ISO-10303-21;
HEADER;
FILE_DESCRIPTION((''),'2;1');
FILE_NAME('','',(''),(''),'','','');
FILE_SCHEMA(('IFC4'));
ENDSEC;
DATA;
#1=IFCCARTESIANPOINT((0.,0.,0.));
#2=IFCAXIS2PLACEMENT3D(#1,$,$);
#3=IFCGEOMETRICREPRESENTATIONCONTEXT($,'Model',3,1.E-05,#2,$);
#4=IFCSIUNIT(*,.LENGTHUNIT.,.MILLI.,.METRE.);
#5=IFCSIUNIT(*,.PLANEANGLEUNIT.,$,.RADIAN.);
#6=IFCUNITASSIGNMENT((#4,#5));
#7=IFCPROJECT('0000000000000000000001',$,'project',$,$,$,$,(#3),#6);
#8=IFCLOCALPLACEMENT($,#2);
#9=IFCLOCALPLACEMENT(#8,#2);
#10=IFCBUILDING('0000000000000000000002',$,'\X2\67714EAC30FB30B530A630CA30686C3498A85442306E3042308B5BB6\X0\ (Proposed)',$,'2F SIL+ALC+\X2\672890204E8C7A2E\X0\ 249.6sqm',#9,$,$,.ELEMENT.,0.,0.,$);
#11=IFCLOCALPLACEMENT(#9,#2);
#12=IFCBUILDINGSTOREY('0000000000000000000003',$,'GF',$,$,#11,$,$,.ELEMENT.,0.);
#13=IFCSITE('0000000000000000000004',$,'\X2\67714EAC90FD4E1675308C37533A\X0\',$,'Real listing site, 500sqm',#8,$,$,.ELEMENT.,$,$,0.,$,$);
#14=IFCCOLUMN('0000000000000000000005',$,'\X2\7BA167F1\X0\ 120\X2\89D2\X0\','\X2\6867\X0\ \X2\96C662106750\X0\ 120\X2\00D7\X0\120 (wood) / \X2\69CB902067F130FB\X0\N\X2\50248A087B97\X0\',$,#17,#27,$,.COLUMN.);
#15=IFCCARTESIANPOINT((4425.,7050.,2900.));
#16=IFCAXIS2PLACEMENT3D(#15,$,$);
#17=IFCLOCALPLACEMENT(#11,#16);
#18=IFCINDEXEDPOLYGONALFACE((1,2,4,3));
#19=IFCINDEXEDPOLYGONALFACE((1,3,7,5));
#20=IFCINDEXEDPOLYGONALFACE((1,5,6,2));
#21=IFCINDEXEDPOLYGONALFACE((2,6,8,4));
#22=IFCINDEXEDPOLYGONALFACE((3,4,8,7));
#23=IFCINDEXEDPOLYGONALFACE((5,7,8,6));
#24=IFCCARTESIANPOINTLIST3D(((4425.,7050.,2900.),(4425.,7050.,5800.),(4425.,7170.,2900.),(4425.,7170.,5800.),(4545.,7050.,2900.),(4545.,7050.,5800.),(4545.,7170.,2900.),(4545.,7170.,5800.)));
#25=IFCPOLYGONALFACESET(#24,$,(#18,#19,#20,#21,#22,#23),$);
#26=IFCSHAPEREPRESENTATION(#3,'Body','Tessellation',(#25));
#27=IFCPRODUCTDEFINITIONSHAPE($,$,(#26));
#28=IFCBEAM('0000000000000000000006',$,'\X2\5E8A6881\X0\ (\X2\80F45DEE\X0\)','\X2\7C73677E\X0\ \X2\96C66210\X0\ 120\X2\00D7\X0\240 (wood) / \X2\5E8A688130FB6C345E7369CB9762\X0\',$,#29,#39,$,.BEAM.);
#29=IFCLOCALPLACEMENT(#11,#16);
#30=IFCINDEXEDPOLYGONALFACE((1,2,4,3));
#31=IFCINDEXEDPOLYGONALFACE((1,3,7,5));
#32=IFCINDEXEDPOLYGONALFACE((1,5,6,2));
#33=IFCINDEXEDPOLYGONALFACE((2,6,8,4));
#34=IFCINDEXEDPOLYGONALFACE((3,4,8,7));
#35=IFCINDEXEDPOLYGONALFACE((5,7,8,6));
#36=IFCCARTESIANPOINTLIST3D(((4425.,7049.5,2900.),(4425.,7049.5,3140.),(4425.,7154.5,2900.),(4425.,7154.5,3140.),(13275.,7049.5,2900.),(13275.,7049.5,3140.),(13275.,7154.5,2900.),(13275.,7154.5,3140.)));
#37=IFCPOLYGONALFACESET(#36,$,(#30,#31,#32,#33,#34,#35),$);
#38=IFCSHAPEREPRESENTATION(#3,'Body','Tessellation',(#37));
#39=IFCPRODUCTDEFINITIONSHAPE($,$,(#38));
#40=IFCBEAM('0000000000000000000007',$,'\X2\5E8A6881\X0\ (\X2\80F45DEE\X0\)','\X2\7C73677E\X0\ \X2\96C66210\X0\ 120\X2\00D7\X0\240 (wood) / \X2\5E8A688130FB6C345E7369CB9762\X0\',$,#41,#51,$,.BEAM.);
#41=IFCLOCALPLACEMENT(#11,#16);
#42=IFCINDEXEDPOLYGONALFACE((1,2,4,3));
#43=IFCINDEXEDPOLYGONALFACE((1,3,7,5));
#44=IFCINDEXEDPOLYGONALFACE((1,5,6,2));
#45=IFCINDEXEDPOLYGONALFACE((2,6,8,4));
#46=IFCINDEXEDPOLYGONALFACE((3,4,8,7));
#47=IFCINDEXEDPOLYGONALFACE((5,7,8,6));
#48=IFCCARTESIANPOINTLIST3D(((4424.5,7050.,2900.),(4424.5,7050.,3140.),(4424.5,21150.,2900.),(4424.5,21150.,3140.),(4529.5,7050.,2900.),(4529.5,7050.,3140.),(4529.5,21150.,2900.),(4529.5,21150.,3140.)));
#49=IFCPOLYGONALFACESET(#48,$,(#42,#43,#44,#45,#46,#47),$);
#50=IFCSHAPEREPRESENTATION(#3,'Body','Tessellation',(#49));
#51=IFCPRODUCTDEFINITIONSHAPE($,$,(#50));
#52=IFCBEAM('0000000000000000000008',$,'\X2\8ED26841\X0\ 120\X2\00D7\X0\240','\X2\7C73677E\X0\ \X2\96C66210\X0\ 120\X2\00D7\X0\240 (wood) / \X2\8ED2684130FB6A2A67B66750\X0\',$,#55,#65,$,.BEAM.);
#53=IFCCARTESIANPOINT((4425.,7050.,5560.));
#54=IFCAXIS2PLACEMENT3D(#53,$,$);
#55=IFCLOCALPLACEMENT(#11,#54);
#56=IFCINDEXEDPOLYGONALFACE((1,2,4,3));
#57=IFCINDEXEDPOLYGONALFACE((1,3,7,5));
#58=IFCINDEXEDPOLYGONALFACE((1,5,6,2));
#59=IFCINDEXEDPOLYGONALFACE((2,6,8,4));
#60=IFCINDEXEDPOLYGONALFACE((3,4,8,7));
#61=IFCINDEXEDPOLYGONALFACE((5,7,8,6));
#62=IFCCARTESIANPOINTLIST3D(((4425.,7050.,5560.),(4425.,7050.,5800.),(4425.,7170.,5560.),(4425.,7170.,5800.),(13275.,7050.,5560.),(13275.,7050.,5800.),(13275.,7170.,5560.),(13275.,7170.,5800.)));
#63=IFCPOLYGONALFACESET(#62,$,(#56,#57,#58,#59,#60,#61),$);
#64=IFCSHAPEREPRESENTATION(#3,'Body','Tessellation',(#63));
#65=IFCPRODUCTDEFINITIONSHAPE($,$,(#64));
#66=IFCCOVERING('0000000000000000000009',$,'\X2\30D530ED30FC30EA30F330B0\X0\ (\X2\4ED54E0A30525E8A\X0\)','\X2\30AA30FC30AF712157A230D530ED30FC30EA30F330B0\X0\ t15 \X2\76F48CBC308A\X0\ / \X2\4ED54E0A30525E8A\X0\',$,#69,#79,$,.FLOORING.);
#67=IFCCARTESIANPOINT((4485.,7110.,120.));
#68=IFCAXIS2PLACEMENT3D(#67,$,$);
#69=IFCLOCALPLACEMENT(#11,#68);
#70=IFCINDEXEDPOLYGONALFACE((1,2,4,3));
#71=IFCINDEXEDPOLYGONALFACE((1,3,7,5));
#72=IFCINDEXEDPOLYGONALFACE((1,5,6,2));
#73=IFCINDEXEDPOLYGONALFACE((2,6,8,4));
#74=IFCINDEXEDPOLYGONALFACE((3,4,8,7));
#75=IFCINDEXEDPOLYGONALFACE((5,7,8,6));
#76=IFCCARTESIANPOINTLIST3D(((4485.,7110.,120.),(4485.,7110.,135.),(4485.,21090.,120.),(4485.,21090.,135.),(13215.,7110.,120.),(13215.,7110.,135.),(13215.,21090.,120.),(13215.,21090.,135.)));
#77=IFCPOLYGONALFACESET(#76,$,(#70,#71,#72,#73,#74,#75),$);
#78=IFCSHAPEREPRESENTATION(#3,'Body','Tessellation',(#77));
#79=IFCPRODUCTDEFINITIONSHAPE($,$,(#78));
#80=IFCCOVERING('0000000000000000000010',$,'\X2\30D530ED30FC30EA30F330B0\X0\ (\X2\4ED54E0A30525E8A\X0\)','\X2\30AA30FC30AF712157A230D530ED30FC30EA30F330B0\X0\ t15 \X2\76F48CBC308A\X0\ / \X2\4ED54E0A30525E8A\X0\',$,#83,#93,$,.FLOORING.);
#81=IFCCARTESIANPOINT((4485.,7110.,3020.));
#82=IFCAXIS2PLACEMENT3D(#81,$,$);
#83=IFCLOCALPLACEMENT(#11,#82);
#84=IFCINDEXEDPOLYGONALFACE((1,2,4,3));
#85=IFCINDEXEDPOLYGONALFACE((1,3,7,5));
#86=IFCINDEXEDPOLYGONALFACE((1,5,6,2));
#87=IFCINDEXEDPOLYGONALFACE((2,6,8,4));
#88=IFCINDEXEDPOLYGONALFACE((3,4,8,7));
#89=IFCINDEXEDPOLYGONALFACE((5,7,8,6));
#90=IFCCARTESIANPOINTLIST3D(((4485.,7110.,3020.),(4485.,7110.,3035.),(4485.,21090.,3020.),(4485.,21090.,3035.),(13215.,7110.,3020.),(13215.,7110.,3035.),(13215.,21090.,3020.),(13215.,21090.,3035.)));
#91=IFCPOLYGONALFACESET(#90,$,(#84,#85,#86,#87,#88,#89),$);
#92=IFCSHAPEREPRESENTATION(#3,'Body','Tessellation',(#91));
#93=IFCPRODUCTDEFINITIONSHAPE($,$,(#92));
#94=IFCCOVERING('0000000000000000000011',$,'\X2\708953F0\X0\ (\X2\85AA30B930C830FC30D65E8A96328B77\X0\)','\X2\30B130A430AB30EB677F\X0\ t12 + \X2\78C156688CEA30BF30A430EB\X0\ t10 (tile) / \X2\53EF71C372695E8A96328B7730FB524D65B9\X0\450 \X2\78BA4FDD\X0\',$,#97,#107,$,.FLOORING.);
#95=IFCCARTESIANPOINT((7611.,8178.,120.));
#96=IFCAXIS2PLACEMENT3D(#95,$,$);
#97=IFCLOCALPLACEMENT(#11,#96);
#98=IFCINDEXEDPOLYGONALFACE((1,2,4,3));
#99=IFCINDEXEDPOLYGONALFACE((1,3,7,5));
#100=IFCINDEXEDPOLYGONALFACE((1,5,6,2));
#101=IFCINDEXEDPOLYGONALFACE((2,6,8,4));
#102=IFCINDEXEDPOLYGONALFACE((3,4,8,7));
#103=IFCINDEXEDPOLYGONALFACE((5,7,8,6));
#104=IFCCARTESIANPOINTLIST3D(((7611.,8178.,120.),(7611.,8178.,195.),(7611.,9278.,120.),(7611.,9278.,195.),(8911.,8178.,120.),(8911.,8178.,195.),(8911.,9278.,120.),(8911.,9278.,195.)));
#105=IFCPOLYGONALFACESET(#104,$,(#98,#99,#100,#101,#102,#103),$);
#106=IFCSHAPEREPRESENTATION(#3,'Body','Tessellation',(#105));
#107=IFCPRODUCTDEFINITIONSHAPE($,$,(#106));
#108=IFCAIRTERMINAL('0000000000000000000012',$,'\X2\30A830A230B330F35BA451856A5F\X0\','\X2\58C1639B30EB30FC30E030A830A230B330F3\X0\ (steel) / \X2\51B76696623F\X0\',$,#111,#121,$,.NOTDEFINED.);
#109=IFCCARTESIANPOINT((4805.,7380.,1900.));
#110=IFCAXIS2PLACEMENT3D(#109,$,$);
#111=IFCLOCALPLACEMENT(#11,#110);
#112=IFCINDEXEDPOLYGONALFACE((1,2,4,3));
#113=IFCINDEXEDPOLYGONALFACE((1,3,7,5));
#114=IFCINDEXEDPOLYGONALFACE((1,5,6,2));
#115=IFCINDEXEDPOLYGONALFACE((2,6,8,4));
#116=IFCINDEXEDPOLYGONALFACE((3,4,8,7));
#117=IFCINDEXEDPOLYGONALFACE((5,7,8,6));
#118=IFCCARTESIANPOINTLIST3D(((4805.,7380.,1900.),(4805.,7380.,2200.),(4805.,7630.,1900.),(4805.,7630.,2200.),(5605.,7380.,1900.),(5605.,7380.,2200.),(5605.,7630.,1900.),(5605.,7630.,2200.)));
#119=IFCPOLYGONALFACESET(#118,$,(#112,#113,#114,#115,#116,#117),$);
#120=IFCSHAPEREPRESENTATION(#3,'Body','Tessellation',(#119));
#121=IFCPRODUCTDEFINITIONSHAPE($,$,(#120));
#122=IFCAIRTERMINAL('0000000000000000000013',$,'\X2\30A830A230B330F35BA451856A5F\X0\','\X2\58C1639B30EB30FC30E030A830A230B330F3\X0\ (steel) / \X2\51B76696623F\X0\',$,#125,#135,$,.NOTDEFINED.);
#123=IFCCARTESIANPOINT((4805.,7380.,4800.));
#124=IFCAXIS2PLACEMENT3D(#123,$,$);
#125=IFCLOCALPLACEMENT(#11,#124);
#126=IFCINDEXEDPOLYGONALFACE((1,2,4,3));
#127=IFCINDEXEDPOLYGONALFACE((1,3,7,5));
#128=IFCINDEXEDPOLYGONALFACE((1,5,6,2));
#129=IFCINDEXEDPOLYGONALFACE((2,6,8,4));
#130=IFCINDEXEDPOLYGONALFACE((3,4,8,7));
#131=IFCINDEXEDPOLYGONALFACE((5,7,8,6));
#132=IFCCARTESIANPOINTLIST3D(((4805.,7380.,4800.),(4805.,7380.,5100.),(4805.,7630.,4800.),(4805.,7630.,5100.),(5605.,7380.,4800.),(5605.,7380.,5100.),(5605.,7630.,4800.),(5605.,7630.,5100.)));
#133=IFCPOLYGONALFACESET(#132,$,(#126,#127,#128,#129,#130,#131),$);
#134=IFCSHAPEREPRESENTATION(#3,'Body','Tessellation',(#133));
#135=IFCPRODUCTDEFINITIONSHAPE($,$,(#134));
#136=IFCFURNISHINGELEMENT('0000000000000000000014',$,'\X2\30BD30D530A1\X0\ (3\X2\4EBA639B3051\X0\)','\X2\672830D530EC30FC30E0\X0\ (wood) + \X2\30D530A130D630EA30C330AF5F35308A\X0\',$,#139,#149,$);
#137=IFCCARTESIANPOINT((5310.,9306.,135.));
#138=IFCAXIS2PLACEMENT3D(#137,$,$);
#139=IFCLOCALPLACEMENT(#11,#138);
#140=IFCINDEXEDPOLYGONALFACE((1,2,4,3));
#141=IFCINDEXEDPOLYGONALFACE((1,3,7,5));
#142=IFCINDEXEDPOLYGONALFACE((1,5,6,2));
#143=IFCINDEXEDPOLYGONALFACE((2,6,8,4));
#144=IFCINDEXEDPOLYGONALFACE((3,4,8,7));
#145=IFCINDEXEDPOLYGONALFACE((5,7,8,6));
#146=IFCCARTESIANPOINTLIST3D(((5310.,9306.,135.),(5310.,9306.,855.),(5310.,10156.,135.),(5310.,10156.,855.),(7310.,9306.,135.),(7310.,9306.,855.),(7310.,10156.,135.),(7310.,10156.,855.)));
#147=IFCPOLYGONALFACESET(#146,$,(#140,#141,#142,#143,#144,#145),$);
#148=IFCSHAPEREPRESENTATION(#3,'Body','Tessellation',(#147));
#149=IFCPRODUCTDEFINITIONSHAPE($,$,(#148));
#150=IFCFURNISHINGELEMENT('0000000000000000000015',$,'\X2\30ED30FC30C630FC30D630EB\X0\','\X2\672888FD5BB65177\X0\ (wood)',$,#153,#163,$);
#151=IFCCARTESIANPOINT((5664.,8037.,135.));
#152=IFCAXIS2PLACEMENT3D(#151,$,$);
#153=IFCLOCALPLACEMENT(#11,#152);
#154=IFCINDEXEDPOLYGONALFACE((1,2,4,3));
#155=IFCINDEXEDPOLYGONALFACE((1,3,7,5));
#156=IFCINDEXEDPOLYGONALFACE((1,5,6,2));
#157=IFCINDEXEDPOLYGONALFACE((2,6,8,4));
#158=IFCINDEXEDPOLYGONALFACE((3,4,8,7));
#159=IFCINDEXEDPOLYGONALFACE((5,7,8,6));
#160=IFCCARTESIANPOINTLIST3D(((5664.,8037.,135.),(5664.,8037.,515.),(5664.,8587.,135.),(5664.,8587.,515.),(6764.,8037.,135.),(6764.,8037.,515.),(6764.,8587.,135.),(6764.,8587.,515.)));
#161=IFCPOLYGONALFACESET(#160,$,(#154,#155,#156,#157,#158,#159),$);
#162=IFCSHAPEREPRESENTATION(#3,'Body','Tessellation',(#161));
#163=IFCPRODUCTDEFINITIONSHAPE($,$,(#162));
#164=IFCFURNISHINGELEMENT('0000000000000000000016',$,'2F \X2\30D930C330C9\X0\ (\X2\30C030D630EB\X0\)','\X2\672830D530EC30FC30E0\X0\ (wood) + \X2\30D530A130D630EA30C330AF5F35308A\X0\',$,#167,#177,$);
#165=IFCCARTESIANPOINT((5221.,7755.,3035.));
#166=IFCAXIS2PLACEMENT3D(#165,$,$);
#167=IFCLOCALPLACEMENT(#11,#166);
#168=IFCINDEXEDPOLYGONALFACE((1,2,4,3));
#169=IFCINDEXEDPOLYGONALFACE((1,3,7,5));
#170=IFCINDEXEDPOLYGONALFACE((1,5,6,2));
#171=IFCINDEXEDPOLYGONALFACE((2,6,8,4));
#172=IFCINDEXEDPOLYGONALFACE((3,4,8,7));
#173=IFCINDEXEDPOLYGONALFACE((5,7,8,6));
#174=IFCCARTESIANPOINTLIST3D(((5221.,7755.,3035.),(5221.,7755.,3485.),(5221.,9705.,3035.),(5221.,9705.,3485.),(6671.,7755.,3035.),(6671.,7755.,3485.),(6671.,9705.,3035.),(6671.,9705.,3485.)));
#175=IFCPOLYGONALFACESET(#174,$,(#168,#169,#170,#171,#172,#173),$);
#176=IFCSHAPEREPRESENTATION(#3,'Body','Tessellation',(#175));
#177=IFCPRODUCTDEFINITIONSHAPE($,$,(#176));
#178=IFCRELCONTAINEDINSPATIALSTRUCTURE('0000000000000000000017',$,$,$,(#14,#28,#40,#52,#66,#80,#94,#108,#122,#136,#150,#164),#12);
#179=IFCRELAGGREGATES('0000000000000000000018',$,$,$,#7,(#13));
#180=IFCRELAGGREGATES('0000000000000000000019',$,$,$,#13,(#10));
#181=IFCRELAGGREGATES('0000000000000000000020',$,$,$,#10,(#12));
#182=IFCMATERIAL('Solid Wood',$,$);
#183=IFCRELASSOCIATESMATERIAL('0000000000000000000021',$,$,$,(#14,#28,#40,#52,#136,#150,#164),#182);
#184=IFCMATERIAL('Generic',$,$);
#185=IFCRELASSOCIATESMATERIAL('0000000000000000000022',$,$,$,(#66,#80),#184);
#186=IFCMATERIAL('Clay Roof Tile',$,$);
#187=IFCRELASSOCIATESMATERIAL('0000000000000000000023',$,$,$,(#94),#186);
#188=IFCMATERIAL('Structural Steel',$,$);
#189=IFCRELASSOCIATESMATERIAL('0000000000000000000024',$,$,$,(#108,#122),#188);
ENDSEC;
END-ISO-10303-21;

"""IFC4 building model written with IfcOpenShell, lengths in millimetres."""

from ifc_helpers import new_model, si_unit, frame, frame_2d, origin, place, context, project, spatial, rectangle, extrude, material, element, save


model = new_model("IFC4")

# Units and contexts
model_context = context("Model", 3, precision=1e-05, world=origin())
ifc_project = project(units=[si_unit("LENGTHUNIT", "METRE", prefix="MILLI"), si_unit("PLANEANGLEUNIT", "RADIAN")], contexts=[model_context])

# Site, building, storey
site_placement = place(None, origin())
site = spatial("IfcSite", under=ifc_project, at=site_placement, Name="東京都世田谷区", ObjectType="Real listing site, 500sqm", CompositionType="ELEMENT", RefElevation=0.0)
building_placement = place(site_placement, origin())
building = spatial("IfcBuilding", under=site, at=building_placement, Name="東京・サウナと水風呂のある家 (Proposed)", ObjectType="2F SIL+ALC+木造二種 249.6sqm", CompositionType="ELEMENT", ElevationOfRefHeight=0.0, ElevationOfTerrain=0.0)
storey_placement = place(building_placement, origin())
storey = spatial("IfcBuildingStorey", under=building, at=storey_placement, Name="GF", CompositionType="ELEMENT", Elevation=0.0)

# Column
ifc_material_1 = material(Name="Solid Wood")
column_1_placement = place(storey_placement, frame((4425.0, 7050.0, 2900.0)))
element("IfcColumn", 1, at=column_1_placement, inside=storey, material=ifc_material_1, Name="管柱 120角", Description="桧 集成材 120×120 (wood) / 構造柱・N値計算", PredefinedType="COLUMN", context=model_context, shape_type="SweptSolid", body=[
    extrude(rectangle(XDim=120.0, YDim=120.0, at=frame_2d((60.0, 60.0))), frame((4425.0, 7050.0, 2900.0)), (0.0, 0.0, 1.0), 2900.0),
])

# Beams
beam_1_placement = place(storey_placement, frame((4425.0, 7050.0, 2900.0)))
element("IfcBeam", 2, at=beam_1_placement, inside=storey, material=ifc_material_1, Name="床梁 (胴差)", Description="米松 集成 120×240 (wood) / 床梁・水平構面", PredefinedType="BEAM", context=model_context, shape_type="SweptSolid", body=[
    extrude(rectangle(XDim=8850.0, YDim=105.0, at=frame_2d((4425.0, 52.0))), frame((4425.0, 7050.0, 2900.0)), (0.0, 0.0, 1.0), 240.0),
])
beam_2_placement = place(storey_placement, frame((4425.0, 7050.0, 2900.0)))
element("IfcBeam", 3, at=beam_2_placement, inside=storey, material=ifc_material_1, Name="床梁 (胴差)", Description="米松 集成 120×240 (wood) / 床梁・水平構面", PredefinedType="BEAM", context=model_context, shape_type="SweptSolid", body=[
    extrude(rectangle(XDim=105.0, YDim=14100.0, at=frame_2d((52.0, 7050.0))), frame((4425.0, 7050.0, 2900.0)), (0.0, 0.0, 1.0), 240.0),
])
beam_3_placement = place(storey_placement, frame((4425.0, 7050.0, 5560.0)))
element("IfcBeam", 4, at=beam_3_placement, inside=storey, material=ifc_material_1, Name="軒桁 120×240", Description="米松 集成 120×240 (wood) / 軒桁・横架材", PredefinedType="BEAM", context=model_context, shape_type="SweptSolid", body=[
    extrude(rectangle(XDim=8850.0, YDim=120.0, at=frame_2d((4425.0, 60.0))), frame((4425.0, 7050.0, 5560.0)), (0.0, 0.0, 1.0), 240.0),
])

# Coverings
ifc_material_2 = material(Name="Generic")
covering_1_placement = place(storey_placement, frame((4485.0, 7110.0, 120.0)))
element("IfcCovering", 5, at=covering_1_placement, inside=storey, material=ifc_material_2, Name="フローリング (仕上げ床)", Description="オーク無垢フローリング t15 直貼り / 仕上げ床", PredefinedType="FLOORING", context=model_context, shape_type="SweptSolid", body=[
    extrude(rectangle(XDim=8730.0, YDim=13980.0, at=frame_2d((4365.0, 6990.0))), frame((4485.0, 7110.0, 120.0)), (0.0, 0.0, 1.0), 15.0),
])
covering_2_placement = place(storey_placement, frame((4485.0, 7110.0, 3020.0)))
element("IfcCovering", 6, at=covering_2_placement, inside=storey, material=ifc_material_2, Name="フローリング (仕上げ床)", Description="オーク無垢フローリング t15 直貼り / 仕上げ床", PredefinedType="FLOORING", context=model_context, shape_type="SweptSolid", body=[
    extrude(rectangle(XDim=8730.0, YDim=13980.0, at=frame_2d((4365.0, 6990.0))), frame((4485.0, 7110.0, 3020.0)), (0.0, 0.0, 1.0), 15.0),
])
ifc_material_3 = material(Name="Clay Roof Tile")
covering_3_placement = place(storey_placement, frame((7611.0, 8178.0, 120.0)))
element("IfcCovering", 7, at=covering_3_placement, inside=storey, material=ifc_material_3, Name="炉台 (薪ストーブ床防護)", Description="ケイカル板 t12 + 磁器質タイル t10 (tile) / 可燃物床防護・前方450 確保", PredefinedType="FLOORING", context=model_context, shape_type="SweptSolid", body=[
    extrude(rectangle(XDim=1300.0, YDim=1100.0, at=frame_2d((650.0, 550.0))), frame((7611.0, 8178.0, 120.0)), (0.0, 0.0, 1.0), 75.0),
])

# Air terminals
ifc_material_4 = material(Name="Structural Steel")
air_terminal_1_placement = place(storey_placement, frame((4805.0, 7380.0, 1900.0)))
element("IfcAirTerminal", 8, at=air_terminal_1_placement, inside=storey, material=ifc_material_4, Name="エアコン室内機", Description="壁掛ルームエアコン (steel) / 冷暖房", PredefinedType="NOTDEFINED", context=model_context, shape_type="SweptSolid", body=[
    extrude(rectangle(XDim=800.0, YDim=250.0, at=frame_2d((400.0, 125.0))), frame((4805.0, 7380.0, 1900.0)), (0.0, 0.0, 1.0), 300.0),
])
air_terminal_2_placement = place(storey_placement, frame((4805.0, 7380.0, 4800.0)))
element("IfcAirTerminal", 9, at=air_terminal_2_placement, inside=storey, material=ifc_material_4, Name="エアコン室内機", Description="壁掛ルームエアコン (steel) / 冷暖房", PredefinedType="NOTDEFINED", context=model_context, shape_type="SweptSolid", body=[
    extrude(rectangle(XDim=800.0, YDim=250.0, at=frame_2d((400.0, 125.0))), frame((4805.0, 7380.0, 4800.0)), (0.0, 0.0, 1.0), 300.0),
])

# Furnishing elements
furnishing_1_placement = place(storey_placement, frame((5310.0, 9306.0, 135.0)))
element("IfcFurnishingElement", 10, at=furnishing_1_placement, inside=storey, material=ifc_material_1, Name="ソファ (3人掛け)", Description="木フレーム (wood) + ファブリック張り", context=model_context, shape_type="SweptSolid", body=[
    extrude(rectangle(XDim=2000.0, YDim=850.0, at=frame_2d((1000.0, 425.0))), frame((5310.0, 9306.0, 135.0)), (0.0, 0.0, 1.0), 720.0),
])
furnishing_2_placement = place(storey_placement, frame((5664.0, 8037.0, 135.0)))
element("IfcFurnishingElement", 11, at=furnishing_2_placement, inside=storey, material=ifc_material_1, Name="ローテーブル", Description="木製家具 (wood)", context=model_context, shape_type="SweptSolid", body=[
    extrude(rectangle(XDim=1100.0, YDim=550.0, at=frame_2d((550.0, 275.0))), frame((5664.0, 8037.0, 135.0)), (0.0, 0.0, 1.0), 380.0),
])
furnishing_3_placement = place(storey_placement, frame((5221.0, 7755.0, 3035.0)))
element("IfcFurnishingElement", 12, at=furnishing_3_placement, inside=storey, material=ifc_material_1, Name="2F ベッド (ダブル)", Description="木フレーム (wood) + ファブリック張り", context=model_context, shape_type="SweptSolid", body=[
    extrude(rectangle(XDim=1450.0, YDim=1950.0, at=frame_2d((725.0, 975.0))), frame((5221.0, 7755.0, 3035.0)), (0.0, 0.0, 1.0), 450.0),
])

save(model, "model.ifc")
